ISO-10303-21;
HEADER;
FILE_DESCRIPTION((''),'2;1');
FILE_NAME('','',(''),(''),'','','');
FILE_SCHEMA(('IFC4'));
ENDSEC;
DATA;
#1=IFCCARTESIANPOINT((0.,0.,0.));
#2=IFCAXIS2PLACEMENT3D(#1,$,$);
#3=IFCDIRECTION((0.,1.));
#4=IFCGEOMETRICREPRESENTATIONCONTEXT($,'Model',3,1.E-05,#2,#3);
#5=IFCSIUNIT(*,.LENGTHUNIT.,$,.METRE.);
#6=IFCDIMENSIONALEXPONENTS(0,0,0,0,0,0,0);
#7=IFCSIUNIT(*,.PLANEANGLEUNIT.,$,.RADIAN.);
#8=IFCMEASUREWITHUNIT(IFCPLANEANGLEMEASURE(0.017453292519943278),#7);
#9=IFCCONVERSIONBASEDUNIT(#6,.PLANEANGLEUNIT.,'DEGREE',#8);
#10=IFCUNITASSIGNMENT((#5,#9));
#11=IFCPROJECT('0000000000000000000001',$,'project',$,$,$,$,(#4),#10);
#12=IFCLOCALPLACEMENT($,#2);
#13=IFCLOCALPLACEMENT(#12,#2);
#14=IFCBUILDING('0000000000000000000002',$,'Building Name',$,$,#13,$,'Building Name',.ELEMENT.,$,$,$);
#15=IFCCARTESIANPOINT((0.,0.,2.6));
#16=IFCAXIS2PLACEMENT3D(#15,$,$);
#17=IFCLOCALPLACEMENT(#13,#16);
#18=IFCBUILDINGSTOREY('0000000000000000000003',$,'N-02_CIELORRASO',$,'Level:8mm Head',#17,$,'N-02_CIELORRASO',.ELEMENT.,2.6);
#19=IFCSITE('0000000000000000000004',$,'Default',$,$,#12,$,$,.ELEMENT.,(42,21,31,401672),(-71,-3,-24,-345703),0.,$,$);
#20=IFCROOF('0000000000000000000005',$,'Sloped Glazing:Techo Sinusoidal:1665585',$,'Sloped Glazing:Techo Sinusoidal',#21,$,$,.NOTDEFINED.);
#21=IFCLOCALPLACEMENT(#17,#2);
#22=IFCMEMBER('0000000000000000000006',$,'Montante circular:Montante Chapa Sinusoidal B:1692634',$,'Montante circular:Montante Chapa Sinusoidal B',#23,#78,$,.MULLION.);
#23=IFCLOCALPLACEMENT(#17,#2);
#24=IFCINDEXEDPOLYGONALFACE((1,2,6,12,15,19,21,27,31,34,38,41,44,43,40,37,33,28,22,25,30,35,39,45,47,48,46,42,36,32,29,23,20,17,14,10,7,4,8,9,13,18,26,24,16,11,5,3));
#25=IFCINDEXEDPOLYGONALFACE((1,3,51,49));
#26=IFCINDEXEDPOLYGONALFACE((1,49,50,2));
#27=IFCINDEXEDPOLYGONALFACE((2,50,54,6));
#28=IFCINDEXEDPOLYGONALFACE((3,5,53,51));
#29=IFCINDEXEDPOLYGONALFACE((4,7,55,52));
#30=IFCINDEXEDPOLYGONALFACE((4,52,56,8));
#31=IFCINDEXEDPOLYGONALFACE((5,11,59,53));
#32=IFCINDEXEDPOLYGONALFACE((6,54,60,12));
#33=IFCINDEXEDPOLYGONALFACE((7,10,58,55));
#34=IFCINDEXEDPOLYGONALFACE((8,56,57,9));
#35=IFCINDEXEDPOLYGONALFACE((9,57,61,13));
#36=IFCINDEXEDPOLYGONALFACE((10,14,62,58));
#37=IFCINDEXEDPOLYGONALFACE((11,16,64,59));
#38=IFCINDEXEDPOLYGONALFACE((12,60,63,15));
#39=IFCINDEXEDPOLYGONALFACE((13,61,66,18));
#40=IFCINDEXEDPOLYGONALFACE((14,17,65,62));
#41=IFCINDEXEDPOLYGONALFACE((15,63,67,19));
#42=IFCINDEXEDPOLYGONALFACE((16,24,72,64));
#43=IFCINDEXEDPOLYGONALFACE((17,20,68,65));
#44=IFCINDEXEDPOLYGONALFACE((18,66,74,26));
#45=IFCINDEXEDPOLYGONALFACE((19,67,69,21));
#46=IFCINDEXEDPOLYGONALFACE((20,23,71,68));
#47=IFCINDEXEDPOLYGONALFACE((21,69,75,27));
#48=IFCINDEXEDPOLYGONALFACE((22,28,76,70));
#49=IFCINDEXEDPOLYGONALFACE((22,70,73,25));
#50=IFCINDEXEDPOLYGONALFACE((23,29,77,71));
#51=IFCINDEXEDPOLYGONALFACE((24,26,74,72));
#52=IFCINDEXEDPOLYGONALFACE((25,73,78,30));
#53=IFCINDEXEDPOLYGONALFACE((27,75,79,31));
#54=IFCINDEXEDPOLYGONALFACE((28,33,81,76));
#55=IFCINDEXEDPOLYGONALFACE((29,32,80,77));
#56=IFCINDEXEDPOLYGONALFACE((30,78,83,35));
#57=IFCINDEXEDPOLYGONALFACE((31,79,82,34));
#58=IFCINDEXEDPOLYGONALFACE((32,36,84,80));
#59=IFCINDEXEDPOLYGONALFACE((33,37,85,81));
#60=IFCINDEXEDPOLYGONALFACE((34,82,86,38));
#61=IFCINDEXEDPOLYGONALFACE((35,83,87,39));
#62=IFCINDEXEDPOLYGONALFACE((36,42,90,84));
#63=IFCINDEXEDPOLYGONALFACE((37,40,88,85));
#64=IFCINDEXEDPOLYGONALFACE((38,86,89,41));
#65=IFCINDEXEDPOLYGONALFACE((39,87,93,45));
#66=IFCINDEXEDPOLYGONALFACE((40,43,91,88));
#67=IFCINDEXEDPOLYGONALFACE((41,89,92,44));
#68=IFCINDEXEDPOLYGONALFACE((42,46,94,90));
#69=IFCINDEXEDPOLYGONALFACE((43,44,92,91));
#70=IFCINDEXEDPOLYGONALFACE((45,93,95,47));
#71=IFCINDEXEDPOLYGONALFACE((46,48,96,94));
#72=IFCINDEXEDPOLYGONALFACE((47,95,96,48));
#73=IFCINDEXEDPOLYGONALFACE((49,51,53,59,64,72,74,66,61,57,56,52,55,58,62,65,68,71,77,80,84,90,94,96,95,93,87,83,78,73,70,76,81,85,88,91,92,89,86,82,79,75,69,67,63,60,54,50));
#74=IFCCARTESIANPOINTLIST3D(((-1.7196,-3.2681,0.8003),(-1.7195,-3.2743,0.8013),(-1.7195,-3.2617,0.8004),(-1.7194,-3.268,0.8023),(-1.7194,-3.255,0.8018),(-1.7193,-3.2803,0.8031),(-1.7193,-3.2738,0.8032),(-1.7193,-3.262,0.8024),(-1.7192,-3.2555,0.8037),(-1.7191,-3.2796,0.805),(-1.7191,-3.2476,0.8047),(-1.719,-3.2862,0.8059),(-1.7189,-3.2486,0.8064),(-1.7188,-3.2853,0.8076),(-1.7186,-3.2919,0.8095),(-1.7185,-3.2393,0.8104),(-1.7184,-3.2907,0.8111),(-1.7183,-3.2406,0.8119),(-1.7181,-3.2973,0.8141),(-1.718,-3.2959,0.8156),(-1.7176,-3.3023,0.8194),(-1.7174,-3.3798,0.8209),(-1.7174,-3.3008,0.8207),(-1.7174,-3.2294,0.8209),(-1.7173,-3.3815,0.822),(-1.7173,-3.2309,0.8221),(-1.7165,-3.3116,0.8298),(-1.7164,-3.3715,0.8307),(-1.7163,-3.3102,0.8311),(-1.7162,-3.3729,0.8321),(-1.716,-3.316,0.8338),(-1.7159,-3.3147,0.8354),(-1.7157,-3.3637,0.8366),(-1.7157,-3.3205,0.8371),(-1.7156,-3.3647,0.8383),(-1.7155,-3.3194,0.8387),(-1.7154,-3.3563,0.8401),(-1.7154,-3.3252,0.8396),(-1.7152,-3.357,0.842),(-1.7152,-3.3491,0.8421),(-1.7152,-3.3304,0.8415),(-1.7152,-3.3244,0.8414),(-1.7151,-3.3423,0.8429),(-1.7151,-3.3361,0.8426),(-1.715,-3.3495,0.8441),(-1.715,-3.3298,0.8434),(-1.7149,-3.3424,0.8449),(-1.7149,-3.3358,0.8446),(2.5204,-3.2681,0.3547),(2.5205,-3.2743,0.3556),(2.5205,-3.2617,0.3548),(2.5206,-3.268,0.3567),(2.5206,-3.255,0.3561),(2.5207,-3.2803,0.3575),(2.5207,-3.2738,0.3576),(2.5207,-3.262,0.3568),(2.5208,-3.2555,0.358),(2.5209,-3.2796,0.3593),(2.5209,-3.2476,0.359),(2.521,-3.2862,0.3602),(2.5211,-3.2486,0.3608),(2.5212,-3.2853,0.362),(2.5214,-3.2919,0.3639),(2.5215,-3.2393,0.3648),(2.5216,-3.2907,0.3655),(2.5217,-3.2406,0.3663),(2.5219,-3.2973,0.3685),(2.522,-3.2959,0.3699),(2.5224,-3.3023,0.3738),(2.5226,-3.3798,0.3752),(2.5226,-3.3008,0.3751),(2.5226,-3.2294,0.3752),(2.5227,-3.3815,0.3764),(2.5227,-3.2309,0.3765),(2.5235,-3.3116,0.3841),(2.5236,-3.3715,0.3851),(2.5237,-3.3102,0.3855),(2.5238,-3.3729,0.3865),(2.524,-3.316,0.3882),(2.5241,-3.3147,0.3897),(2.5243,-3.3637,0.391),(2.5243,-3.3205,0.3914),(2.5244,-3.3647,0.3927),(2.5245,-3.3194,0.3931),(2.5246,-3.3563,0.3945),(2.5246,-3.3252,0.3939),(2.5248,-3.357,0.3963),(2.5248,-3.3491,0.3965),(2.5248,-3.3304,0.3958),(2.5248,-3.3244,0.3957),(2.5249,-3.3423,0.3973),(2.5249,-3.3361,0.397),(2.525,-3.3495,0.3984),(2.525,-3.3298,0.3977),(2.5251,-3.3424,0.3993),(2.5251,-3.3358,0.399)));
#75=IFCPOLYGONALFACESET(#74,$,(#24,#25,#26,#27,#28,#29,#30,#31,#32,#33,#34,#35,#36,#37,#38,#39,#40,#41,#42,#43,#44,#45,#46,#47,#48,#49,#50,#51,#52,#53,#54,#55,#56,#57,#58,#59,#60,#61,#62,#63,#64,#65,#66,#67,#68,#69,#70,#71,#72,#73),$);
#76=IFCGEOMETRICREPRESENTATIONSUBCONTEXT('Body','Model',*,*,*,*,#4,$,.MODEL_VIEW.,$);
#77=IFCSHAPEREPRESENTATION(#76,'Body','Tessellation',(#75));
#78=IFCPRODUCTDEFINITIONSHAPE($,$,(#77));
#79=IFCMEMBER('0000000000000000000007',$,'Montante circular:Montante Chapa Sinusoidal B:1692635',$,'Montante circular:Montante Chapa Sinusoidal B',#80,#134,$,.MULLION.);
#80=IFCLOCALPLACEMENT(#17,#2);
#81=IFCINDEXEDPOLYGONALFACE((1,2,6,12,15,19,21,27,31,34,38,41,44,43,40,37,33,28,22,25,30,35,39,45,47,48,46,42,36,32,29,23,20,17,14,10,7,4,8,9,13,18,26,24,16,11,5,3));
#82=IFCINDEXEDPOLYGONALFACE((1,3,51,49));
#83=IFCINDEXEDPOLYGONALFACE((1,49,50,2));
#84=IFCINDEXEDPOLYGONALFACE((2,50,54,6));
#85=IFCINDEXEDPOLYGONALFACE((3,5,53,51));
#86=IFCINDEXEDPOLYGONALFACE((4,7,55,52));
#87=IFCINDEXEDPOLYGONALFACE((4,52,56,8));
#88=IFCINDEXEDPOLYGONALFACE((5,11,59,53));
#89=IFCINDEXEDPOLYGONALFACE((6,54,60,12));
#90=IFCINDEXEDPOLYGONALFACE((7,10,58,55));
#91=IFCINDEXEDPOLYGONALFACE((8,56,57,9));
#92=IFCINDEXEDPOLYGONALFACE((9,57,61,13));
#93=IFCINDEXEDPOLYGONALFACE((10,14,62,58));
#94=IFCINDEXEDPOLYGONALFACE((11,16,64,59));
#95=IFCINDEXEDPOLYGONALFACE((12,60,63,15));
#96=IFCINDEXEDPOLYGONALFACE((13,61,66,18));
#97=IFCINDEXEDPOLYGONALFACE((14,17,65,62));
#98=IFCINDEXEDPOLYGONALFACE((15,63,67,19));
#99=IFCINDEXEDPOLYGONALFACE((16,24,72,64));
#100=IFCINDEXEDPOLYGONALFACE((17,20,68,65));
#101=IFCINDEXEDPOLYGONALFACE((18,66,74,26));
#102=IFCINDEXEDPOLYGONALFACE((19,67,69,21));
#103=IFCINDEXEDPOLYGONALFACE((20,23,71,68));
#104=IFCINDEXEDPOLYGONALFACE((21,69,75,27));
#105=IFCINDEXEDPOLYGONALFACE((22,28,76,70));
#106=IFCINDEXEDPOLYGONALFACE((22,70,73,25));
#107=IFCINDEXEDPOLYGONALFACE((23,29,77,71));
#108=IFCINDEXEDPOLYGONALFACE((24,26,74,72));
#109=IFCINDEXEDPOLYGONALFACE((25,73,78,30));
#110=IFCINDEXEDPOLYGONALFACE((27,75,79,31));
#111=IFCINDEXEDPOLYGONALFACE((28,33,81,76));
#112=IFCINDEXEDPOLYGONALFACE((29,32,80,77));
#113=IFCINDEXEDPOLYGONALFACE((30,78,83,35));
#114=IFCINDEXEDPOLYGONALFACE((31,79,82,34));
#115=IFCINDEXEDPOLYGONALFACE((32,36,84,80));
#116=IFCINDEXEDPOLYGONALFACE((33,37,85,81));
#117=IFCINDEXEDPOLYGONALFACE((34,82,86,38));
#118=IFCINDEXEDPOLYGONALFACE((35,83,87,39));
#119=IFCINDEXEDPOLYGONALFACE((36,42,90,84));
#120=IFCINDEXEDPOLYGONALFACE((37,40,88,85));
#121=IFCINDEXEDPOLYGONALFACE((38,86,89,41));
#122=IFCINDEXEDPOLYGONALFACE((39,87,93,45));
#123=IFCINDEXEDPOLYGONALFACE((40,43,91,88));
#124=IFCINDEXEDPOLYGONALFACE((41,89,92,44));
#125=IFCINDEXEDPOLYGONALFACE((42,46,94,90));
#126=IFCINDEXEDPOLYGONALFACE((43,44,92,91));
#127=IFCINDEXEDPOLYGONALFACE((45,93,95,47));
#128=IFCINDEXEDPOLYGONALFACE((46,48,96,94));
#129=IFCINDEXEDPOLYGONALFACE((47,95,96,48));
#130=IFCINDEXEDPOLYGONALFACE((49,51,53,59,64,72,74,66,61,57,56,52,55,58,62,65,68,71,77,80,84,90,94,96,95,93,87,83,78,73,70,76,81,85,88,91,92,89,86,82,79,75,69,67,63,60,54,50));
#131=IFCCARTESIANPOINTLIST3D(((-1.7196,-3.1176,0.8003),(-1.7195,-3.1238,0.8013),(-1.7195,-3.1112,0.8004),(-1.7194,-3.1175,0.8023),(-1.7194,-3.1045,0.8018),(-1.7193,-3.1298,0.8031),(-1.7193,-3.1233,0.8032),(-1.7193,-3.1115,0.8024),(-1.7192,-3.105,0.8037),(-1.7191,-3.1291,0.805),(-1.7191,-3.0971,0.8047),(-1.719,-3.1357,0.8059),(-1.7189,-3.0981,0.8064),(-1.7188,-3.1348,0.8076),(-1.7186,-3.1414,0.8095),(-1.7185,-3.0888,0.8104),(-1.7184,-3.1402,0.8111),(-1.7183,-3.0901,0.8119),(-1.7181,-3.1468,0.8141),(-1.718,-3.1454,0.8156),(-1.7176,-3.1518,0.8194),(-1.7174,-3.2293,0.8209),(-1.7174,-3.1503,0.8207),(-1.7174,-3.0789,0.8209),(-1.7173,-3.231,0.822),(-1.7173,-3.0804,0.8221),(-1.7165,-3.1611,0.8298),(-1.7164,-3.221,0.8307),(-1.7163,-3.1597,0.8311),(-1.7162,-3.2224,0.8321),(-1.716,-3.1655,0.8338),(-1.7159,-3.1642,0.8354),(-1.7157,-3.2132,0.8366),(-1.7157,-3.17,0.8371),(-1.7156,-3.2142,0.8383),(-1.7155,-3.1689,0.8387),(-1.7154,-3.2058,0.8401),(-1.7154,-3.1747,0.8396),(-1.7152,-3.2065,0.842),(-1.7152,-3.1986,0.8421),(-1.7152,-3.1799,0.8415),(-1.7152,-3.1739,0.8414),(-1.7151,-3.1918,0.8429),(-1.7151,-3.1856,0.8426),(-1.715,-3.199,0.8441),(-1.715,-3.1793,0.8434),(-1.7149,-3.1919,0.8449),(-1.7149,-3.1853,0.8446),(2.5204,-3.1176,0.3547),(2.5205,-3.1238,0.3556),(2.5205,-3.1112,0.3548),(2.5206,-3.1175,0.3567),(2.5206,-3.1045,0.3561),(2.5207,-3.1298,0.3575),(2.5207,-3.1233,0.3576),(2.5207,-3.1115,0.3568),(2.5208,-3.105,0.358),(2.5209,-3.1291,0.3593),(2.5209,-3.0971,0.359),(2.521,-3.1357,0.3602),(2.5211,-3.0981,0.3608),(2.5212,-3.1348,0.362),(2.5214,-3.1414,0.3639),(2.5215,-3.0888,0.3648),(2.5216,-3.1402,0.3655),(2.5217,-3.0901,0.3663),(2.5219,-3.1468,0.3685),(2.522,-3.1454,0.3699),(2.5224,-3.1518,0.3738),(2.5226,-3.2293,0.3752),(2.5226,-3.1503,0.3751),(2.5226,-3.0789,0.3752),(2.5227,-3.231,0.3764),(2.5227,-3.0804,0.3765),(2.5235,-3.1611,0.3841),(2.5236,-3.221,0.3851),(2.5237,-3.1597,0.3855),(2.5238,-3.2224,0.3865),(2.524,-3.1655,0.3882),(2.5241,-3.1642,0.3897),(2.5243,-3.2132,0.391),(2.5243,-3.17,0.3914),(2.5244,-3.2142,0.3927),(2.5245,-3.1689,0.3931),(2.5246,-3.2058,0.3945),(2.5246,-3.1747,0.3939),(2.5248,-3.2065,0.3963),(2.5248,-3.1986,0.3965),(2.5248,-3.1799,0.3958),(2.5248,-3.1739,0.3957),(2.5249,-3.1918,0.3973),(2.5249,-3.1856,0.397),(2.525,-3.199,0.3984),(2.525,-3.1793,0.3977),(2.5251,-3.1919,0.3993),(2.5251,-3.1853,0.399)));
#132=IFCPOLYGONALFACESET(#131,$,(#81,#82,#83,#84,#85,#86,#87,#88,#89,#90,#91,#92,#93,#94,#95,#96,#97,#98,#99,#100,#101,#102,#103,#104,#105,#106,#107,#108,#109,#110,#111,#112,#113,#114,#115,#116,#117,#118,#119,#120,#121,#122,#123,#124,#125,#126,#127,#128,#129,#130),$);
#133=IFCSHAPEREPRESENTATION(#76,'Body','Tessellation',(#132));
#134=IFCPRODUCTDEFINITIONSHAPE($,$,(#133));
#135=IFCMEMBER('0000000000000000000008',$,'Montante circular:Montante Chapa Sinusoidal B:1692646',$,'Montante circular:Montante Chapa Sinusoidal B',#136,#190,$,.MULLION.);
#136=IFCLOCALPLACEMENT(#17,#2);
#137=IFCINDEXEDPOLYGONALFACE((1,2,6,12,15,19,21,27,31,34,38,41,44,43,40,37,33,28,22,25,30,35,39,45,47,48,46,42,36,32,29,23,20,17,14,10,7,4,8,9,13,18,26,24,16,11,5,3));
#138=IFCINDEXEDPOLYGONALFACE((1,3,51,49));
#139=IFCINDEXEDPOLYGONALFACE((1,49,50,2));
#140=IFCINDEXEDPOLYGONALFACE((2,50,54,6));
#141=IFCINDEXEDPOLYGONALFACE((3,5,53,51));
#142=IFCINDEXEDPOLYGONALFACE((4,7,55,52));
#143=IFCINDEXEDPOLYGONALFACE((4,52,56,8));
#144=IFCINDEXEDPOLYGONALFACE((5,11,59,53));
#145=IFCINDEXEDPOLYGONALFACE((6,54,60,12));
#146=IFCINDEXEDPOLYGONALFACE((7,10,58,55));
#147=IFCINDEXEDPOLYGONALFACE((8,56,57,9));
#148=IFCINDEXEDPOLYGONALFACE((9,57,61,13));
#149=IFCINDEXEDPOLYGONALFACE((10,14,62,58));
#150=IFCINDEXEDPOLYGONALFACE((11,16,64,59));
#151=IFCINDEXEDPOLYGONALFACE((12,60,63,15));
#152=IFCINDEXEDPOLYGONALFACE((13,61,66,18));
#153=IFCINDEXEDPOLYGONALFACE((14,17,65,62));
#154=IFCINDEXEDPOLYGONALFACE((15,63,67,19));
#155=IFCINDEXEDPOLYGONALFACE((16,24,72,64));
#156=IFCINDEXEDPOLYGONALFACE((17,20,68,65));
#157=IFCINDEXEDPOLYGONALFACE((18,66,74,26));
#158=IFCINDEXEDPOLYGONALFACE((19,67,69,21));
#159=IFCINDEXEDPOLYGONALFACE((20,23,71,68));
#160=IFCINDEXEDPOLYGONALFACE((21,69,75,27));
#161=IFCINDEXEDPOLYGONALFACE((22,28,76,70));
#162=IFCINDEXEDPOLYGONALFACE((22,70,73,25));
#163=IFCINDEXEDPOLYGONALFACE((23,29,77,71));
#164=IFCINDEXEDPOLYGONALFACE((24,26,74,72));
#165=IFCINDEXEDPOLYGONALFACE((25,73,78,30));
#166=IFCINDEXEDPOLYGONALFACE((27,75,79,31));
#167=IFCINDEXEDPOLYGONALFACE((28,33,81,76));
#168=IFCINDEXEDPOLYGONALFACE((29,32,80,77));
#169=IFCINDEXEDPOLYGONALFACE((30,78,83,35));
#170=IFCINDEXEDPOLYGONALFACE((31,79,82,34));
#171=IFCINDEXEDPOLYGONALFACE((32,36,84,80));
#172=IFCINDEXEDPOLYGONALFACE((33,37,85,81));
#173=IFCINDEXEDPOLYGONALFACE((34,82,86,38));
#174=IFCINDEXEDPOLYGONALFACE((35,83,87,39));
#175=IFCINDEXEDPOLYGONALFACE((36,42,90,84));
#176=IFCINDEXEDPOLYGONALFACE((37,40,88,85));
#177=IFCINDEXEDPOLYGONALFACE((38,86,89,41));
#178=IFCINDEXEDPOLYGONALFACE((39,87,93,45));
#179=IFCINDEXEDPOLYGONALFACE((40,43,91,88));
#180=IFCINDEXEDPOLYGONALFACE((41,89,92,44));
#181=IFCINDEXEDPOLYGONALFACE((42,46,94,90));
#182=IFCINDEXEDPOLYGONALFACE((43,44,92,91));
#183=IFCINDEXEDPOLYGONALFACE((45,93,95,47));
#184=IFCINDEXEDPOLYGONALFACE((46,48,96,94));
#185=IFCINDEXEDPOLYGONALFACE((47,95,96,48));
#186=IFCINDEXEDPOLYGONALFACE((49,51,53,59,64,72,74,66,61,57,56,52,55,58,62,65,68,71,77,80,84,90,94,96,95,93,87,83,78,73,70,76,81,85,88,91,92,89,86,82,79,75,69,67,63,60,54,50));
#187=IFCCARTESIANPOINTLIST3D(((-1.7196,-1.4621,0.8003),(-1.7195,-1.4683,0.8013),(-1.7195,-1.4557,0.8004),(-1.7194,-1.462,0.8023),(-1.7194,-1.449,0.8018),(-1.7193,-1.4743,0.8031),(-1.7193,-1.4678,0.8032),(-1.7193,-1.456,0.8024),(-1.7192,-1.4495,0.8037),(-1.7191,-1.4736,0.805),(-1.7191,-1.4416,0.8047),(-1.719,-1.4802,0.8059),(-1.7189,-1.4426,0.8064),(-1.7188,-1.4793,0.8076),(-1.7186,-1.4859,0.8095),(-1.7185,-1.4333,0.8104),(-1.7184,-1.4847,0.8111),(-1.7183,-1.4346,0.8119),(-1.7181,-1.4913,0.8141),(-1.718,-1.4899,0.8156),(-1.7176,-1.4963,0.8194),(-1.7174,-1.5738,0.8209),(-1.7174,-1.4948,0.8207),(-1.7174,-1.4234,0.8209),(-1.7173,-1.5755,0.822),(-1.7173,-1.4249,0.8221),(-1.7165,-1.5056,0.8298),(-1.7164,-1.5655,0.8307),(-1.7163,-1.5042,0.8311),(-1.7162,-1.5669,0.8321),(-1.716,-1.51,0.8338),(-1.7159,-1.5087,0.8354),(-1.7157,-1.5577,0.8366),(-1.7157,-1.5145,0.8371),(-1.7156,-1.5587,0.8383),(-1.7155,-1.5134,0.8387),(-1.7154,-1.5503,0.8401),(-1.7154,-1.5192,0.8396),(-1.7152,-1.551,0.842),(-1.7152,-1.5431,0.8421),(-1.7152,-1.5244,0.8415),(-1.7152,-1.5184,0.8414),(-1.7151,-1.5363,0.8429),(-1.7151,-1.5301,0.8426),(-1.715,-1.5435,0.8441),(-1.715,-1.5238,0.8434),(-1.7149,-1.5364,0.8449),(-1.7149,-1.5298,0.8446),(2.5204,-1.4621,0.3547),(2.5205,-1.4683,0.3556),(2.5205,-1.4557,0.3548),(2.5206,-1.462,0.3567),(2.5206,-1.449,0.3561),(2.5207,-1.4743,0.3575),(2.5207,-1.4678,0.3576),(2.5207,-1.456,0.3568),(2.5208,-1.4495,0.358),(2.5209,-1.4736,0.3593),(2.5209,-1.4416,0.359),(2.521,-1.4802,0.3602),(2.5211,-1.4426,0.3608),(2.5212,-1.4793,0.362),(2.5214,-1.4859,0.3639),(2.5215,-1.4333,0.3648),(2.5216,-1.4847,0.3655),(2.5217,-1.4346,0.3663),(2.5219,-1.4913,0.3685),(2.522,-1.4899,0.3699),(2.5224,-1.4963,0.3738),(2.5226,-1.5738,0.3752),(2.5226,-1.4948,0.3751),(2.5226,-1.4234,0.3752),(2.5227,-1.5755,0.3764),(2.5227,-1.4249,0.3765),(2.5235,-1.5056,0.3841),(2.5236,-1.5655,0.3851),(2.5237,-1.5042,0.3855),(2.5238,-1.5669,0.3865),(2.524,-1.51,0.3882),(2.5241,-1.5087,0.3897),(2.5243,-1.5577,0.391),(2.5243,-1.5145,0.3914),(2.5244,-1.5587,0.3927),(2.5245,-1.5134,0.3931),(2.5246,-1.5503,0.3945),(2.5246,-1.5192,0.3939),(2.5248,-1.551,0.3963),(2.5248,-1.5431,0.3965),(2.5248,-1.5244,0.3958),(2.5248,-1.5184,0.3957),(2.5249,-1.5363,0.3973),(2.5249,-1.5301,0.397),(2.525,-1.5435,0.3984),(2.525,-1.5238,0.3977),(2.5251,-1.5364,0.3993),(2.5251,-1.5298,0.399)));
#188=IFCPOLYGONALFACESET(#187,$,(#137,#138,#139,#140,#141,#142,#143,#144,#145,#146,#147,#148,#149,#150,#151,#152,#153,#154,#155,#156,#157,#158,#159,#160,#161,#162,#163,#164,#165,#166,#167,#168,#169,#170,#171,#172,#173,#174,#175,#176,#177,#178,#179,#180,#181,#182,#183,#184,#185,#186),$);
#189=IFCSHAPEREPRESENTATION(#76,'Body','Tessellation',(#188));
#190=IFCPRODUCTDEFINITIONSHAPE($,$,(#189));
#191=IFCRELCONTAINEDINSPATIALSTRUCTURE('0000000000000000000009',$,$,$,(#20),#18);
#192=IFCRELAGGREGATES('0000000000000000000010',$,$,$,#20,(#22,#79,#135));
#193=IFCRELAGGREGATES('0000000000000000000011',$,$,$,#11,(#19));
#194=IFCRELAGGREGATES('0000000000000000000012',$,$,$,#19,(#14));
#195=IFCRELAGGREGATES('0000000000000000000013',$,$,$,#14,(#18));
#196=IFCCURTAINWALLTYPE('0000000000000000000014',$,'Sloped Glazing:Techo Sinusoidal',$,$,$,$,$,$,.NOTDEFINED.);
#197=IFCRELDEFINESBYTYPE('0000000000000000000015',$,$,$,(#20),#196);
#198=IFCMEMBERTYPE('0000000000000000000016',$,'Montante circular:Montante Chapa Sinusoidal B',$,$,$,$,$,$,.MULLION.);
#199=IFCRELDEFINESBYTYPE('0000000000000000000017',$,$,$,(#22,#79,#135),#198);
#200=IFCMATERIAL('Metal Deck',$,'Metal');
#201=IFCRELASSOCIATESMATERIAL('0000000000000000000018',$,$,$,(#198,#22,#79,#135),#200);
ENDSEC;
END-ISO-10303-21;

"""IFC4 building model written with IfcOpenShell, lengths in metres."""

from ifc_helpers import new_model, entity, si_unit, converted_unit, direction, frame, origin, place, context, subcontext, project, spatial, indexed_curve, outline, extrude, source, transform, mapped, material, type_object, type_shapes, element, aggregate, save


model = new_model("IFC4")

# Units and contexts
model_context = context("Model", 3, precision=1e-05, world=origin(), true_north=direction((0.0, 1.0)))
body_context = subcontext(model_context, "Body", "Model", "MODEL_VIEW")
ifc_project = project(units=[si_unit("LENGTHUNIT", "METRE"), converted_unit("PLANEANGLEUNIT", "DEGREE", entity("IfcPlaneAngleMeasure", 0.017453292519943278), si_unit("PLANEANGLEUNIT", "RADIAN"), dimensions=[0, 0, 0, 0, 0, 0, 0])], contexts=[model_context])

# Site, building, storey
site_placement = place(None, origin())
site = spatial("IfcSite", under=ifc_project, at=site_placement, Name="Default", CompositionType="ELEMENT", RefLatitude=(42, 21, 31, 401672), RefLongitude=(-71, -3, -24, -345703), RefElevation=0.0)
building_placement = place(site_placement, origin())
building = spatial("IfcBuilding", under=site, at=building_placement, Name="Building Name", LongName="Building Name", CompositionType="ELEMENT")
storey_placement = place(building_placement, frame((0.0, 0.0, 2.6)))
storey = spatial("IfcBuildingStorey", under=building, at=storey_placement, Name="N-02_CIELORRASO", ObjectType="Level:8mm Head", LongName="N-02_CIELORRASO", CompositionType="ELEMENT", Elevation=2.6)

# Roof, members
curtain_wall_type = type_object("IfcCurtainWallType", Name="Sloped Glazing:Techo Sinusoidal", PredefinedType="NOTDEFINED")
roof_1_placement = place(storey_placement, frame((0.0, 0.0, -2.6)))
roof_1 = element("IfcRoof", 1, at=roof_1_placement, inside=storey, type_object=curtain_wall_type, Name="Sloped Glazing:Techo Sinusoidal:1665585", ObjectType="Sloped Glazing:Techo Sinusoidal", PredefinedType="NOTDEFINED")
ifc_material = material(Name="Metal Deck", Category="Metal")
member_type_1 = type_object("IfcMemberType", Name="Montante circular:Montante Chapa Sinusoidal B", PredefinedType="MULLION", material=ifc_material)
shared_shape_1 = source(origin(), body_context, "Body", "SweptSolid", [
    extrude(outline(indexed_curve([(0.0595, -0.0443), (0.0615, -0.0443), (0.0603, -0.031), (0.0572, -0.0213), (0.053, -0.0138), (0.0481, -0.0078), (0.0427, -0.003), (0.0372, 0.0005), (0.0315, 0.0029), (0.0259, 0.0044), (0.0203, 0.0051), (0.0146, 0.005), (0.0084, 0.0041), (-0.0053, 0.0009), (-0.0123, -0.0005), (-0.0191, -0.0012), (-0.0256, -0.001), (-0.0317, 0.0001), (-0.0375, 0.0019), (-0.0428, 0.0046), (-0.0477, 0.0081), (-0.0522, 0.0128), (-0.0563, 0.0191), (-0.0597, 0.0282), (-0.0617, 0.0421), (-0.0637, 0.042), (-0.0616, 0.0277), (-0.0581, 0.0182), (-0.0537, 0.0116), (-0.049, 0.0066), (-0.0438, 0.0028), (-0.0382, 0.0001), (-0.0322, -0.0019), (-0.0258, -0.003), (-0.019, -0.0032), (-0.012, -0.0025), (-0.0048, -0.0011), (0.0088, 0.0021), (0.0147, 0.003), (0.0202, 0.0031), (0.0255, 0.0024), (0.0309, 0.001), (0.0362, -0.0013), (0.0415, -0.0046), (0.0466, -0.0092), (0.0513, -0.0149), (0.0554, -0.0221), (0.0584, -0.0314), (0.0595, -0.0443)], self_intersect=False)), frame((-0.007, 0.0228, -4.2634), z_axis=(0.0, 0.0, 1.0), x_axis=(-0.819152, -0.573576, 0.0)), (0.0, 0.0, 1.0), 4.2634),
])
type_shapes(member_type_1, [shared_shape_1])
member_1_placement = place(roof_1_placement, frame((-1.7148, -3.2986, 3.4456), z_axis=(-0.994522, 0.0, 0.104528), x_axis=(0.0, 1.0, 0.0)))
member_1 = element("IfcMember", 2, at=member_1_placement, type_object=member_type_1, material=ifc_material, Name="Montante circular:Montante Chapa Sinusoidal B:1692634", ObjectType="Montante circular:Montante Chapa Sinusoidal B", PredefinedType="MULLION", context=body_context, shape_type="MappedRepresentation", body=[
    mapped(shared_shape_1, transform((0.0, 0.0, 0.0), scale=1.0)),
])
member_2_placement = place(roof_1_placement, frame((-1.7148, -3.1481, 3.4456), z_axis=(-0.994522, 0.0, 0.104528), x_axis=(0.0, 1.0, 0.0)))
member_2 = element("IfcMember", 3, at=member_2_placement, type_object=member_type_1, material=ifc_material, Name="Montante circular:Montante Chapa Sinusoidal B:1692635", ObjectType="Montante circular:Montante Chapa Sinusoidal B", PredefinedType="MULLION", context=body_context, shape_type="MappedRepresentation", body=[
    mapped(shared_shape_1, transform((0.0, 0.0, 0.0), scale=1.0)),
])
member_3_placement = place(roof_1_placement, frame((-1.7148, -1.4926, 3.4456), z_axis=(-0.994522, 0.0, 0.104528), x_axis=(0.0, 1.0, 0.0)))
member_3 = element("IfcMember", 4, at=member_3_placement, type_object=member_type_1, material=ifc_material, Name="Montante circular:Montante Chapa Sinusoidal B:1692646", ObjectType="Montante circular:Montante Chapa Sinusoidal B", PredefinedType="MULLION", context=body_context, shape_type="MappedRepresentation", body=[
    mapped(shared_shape_1, transform((0.0, 0.0, 0.0), scale=1.0)),
])
aggregate(roof_1, [member_1, member_2, member_3])

save(model, "model.ifc")
